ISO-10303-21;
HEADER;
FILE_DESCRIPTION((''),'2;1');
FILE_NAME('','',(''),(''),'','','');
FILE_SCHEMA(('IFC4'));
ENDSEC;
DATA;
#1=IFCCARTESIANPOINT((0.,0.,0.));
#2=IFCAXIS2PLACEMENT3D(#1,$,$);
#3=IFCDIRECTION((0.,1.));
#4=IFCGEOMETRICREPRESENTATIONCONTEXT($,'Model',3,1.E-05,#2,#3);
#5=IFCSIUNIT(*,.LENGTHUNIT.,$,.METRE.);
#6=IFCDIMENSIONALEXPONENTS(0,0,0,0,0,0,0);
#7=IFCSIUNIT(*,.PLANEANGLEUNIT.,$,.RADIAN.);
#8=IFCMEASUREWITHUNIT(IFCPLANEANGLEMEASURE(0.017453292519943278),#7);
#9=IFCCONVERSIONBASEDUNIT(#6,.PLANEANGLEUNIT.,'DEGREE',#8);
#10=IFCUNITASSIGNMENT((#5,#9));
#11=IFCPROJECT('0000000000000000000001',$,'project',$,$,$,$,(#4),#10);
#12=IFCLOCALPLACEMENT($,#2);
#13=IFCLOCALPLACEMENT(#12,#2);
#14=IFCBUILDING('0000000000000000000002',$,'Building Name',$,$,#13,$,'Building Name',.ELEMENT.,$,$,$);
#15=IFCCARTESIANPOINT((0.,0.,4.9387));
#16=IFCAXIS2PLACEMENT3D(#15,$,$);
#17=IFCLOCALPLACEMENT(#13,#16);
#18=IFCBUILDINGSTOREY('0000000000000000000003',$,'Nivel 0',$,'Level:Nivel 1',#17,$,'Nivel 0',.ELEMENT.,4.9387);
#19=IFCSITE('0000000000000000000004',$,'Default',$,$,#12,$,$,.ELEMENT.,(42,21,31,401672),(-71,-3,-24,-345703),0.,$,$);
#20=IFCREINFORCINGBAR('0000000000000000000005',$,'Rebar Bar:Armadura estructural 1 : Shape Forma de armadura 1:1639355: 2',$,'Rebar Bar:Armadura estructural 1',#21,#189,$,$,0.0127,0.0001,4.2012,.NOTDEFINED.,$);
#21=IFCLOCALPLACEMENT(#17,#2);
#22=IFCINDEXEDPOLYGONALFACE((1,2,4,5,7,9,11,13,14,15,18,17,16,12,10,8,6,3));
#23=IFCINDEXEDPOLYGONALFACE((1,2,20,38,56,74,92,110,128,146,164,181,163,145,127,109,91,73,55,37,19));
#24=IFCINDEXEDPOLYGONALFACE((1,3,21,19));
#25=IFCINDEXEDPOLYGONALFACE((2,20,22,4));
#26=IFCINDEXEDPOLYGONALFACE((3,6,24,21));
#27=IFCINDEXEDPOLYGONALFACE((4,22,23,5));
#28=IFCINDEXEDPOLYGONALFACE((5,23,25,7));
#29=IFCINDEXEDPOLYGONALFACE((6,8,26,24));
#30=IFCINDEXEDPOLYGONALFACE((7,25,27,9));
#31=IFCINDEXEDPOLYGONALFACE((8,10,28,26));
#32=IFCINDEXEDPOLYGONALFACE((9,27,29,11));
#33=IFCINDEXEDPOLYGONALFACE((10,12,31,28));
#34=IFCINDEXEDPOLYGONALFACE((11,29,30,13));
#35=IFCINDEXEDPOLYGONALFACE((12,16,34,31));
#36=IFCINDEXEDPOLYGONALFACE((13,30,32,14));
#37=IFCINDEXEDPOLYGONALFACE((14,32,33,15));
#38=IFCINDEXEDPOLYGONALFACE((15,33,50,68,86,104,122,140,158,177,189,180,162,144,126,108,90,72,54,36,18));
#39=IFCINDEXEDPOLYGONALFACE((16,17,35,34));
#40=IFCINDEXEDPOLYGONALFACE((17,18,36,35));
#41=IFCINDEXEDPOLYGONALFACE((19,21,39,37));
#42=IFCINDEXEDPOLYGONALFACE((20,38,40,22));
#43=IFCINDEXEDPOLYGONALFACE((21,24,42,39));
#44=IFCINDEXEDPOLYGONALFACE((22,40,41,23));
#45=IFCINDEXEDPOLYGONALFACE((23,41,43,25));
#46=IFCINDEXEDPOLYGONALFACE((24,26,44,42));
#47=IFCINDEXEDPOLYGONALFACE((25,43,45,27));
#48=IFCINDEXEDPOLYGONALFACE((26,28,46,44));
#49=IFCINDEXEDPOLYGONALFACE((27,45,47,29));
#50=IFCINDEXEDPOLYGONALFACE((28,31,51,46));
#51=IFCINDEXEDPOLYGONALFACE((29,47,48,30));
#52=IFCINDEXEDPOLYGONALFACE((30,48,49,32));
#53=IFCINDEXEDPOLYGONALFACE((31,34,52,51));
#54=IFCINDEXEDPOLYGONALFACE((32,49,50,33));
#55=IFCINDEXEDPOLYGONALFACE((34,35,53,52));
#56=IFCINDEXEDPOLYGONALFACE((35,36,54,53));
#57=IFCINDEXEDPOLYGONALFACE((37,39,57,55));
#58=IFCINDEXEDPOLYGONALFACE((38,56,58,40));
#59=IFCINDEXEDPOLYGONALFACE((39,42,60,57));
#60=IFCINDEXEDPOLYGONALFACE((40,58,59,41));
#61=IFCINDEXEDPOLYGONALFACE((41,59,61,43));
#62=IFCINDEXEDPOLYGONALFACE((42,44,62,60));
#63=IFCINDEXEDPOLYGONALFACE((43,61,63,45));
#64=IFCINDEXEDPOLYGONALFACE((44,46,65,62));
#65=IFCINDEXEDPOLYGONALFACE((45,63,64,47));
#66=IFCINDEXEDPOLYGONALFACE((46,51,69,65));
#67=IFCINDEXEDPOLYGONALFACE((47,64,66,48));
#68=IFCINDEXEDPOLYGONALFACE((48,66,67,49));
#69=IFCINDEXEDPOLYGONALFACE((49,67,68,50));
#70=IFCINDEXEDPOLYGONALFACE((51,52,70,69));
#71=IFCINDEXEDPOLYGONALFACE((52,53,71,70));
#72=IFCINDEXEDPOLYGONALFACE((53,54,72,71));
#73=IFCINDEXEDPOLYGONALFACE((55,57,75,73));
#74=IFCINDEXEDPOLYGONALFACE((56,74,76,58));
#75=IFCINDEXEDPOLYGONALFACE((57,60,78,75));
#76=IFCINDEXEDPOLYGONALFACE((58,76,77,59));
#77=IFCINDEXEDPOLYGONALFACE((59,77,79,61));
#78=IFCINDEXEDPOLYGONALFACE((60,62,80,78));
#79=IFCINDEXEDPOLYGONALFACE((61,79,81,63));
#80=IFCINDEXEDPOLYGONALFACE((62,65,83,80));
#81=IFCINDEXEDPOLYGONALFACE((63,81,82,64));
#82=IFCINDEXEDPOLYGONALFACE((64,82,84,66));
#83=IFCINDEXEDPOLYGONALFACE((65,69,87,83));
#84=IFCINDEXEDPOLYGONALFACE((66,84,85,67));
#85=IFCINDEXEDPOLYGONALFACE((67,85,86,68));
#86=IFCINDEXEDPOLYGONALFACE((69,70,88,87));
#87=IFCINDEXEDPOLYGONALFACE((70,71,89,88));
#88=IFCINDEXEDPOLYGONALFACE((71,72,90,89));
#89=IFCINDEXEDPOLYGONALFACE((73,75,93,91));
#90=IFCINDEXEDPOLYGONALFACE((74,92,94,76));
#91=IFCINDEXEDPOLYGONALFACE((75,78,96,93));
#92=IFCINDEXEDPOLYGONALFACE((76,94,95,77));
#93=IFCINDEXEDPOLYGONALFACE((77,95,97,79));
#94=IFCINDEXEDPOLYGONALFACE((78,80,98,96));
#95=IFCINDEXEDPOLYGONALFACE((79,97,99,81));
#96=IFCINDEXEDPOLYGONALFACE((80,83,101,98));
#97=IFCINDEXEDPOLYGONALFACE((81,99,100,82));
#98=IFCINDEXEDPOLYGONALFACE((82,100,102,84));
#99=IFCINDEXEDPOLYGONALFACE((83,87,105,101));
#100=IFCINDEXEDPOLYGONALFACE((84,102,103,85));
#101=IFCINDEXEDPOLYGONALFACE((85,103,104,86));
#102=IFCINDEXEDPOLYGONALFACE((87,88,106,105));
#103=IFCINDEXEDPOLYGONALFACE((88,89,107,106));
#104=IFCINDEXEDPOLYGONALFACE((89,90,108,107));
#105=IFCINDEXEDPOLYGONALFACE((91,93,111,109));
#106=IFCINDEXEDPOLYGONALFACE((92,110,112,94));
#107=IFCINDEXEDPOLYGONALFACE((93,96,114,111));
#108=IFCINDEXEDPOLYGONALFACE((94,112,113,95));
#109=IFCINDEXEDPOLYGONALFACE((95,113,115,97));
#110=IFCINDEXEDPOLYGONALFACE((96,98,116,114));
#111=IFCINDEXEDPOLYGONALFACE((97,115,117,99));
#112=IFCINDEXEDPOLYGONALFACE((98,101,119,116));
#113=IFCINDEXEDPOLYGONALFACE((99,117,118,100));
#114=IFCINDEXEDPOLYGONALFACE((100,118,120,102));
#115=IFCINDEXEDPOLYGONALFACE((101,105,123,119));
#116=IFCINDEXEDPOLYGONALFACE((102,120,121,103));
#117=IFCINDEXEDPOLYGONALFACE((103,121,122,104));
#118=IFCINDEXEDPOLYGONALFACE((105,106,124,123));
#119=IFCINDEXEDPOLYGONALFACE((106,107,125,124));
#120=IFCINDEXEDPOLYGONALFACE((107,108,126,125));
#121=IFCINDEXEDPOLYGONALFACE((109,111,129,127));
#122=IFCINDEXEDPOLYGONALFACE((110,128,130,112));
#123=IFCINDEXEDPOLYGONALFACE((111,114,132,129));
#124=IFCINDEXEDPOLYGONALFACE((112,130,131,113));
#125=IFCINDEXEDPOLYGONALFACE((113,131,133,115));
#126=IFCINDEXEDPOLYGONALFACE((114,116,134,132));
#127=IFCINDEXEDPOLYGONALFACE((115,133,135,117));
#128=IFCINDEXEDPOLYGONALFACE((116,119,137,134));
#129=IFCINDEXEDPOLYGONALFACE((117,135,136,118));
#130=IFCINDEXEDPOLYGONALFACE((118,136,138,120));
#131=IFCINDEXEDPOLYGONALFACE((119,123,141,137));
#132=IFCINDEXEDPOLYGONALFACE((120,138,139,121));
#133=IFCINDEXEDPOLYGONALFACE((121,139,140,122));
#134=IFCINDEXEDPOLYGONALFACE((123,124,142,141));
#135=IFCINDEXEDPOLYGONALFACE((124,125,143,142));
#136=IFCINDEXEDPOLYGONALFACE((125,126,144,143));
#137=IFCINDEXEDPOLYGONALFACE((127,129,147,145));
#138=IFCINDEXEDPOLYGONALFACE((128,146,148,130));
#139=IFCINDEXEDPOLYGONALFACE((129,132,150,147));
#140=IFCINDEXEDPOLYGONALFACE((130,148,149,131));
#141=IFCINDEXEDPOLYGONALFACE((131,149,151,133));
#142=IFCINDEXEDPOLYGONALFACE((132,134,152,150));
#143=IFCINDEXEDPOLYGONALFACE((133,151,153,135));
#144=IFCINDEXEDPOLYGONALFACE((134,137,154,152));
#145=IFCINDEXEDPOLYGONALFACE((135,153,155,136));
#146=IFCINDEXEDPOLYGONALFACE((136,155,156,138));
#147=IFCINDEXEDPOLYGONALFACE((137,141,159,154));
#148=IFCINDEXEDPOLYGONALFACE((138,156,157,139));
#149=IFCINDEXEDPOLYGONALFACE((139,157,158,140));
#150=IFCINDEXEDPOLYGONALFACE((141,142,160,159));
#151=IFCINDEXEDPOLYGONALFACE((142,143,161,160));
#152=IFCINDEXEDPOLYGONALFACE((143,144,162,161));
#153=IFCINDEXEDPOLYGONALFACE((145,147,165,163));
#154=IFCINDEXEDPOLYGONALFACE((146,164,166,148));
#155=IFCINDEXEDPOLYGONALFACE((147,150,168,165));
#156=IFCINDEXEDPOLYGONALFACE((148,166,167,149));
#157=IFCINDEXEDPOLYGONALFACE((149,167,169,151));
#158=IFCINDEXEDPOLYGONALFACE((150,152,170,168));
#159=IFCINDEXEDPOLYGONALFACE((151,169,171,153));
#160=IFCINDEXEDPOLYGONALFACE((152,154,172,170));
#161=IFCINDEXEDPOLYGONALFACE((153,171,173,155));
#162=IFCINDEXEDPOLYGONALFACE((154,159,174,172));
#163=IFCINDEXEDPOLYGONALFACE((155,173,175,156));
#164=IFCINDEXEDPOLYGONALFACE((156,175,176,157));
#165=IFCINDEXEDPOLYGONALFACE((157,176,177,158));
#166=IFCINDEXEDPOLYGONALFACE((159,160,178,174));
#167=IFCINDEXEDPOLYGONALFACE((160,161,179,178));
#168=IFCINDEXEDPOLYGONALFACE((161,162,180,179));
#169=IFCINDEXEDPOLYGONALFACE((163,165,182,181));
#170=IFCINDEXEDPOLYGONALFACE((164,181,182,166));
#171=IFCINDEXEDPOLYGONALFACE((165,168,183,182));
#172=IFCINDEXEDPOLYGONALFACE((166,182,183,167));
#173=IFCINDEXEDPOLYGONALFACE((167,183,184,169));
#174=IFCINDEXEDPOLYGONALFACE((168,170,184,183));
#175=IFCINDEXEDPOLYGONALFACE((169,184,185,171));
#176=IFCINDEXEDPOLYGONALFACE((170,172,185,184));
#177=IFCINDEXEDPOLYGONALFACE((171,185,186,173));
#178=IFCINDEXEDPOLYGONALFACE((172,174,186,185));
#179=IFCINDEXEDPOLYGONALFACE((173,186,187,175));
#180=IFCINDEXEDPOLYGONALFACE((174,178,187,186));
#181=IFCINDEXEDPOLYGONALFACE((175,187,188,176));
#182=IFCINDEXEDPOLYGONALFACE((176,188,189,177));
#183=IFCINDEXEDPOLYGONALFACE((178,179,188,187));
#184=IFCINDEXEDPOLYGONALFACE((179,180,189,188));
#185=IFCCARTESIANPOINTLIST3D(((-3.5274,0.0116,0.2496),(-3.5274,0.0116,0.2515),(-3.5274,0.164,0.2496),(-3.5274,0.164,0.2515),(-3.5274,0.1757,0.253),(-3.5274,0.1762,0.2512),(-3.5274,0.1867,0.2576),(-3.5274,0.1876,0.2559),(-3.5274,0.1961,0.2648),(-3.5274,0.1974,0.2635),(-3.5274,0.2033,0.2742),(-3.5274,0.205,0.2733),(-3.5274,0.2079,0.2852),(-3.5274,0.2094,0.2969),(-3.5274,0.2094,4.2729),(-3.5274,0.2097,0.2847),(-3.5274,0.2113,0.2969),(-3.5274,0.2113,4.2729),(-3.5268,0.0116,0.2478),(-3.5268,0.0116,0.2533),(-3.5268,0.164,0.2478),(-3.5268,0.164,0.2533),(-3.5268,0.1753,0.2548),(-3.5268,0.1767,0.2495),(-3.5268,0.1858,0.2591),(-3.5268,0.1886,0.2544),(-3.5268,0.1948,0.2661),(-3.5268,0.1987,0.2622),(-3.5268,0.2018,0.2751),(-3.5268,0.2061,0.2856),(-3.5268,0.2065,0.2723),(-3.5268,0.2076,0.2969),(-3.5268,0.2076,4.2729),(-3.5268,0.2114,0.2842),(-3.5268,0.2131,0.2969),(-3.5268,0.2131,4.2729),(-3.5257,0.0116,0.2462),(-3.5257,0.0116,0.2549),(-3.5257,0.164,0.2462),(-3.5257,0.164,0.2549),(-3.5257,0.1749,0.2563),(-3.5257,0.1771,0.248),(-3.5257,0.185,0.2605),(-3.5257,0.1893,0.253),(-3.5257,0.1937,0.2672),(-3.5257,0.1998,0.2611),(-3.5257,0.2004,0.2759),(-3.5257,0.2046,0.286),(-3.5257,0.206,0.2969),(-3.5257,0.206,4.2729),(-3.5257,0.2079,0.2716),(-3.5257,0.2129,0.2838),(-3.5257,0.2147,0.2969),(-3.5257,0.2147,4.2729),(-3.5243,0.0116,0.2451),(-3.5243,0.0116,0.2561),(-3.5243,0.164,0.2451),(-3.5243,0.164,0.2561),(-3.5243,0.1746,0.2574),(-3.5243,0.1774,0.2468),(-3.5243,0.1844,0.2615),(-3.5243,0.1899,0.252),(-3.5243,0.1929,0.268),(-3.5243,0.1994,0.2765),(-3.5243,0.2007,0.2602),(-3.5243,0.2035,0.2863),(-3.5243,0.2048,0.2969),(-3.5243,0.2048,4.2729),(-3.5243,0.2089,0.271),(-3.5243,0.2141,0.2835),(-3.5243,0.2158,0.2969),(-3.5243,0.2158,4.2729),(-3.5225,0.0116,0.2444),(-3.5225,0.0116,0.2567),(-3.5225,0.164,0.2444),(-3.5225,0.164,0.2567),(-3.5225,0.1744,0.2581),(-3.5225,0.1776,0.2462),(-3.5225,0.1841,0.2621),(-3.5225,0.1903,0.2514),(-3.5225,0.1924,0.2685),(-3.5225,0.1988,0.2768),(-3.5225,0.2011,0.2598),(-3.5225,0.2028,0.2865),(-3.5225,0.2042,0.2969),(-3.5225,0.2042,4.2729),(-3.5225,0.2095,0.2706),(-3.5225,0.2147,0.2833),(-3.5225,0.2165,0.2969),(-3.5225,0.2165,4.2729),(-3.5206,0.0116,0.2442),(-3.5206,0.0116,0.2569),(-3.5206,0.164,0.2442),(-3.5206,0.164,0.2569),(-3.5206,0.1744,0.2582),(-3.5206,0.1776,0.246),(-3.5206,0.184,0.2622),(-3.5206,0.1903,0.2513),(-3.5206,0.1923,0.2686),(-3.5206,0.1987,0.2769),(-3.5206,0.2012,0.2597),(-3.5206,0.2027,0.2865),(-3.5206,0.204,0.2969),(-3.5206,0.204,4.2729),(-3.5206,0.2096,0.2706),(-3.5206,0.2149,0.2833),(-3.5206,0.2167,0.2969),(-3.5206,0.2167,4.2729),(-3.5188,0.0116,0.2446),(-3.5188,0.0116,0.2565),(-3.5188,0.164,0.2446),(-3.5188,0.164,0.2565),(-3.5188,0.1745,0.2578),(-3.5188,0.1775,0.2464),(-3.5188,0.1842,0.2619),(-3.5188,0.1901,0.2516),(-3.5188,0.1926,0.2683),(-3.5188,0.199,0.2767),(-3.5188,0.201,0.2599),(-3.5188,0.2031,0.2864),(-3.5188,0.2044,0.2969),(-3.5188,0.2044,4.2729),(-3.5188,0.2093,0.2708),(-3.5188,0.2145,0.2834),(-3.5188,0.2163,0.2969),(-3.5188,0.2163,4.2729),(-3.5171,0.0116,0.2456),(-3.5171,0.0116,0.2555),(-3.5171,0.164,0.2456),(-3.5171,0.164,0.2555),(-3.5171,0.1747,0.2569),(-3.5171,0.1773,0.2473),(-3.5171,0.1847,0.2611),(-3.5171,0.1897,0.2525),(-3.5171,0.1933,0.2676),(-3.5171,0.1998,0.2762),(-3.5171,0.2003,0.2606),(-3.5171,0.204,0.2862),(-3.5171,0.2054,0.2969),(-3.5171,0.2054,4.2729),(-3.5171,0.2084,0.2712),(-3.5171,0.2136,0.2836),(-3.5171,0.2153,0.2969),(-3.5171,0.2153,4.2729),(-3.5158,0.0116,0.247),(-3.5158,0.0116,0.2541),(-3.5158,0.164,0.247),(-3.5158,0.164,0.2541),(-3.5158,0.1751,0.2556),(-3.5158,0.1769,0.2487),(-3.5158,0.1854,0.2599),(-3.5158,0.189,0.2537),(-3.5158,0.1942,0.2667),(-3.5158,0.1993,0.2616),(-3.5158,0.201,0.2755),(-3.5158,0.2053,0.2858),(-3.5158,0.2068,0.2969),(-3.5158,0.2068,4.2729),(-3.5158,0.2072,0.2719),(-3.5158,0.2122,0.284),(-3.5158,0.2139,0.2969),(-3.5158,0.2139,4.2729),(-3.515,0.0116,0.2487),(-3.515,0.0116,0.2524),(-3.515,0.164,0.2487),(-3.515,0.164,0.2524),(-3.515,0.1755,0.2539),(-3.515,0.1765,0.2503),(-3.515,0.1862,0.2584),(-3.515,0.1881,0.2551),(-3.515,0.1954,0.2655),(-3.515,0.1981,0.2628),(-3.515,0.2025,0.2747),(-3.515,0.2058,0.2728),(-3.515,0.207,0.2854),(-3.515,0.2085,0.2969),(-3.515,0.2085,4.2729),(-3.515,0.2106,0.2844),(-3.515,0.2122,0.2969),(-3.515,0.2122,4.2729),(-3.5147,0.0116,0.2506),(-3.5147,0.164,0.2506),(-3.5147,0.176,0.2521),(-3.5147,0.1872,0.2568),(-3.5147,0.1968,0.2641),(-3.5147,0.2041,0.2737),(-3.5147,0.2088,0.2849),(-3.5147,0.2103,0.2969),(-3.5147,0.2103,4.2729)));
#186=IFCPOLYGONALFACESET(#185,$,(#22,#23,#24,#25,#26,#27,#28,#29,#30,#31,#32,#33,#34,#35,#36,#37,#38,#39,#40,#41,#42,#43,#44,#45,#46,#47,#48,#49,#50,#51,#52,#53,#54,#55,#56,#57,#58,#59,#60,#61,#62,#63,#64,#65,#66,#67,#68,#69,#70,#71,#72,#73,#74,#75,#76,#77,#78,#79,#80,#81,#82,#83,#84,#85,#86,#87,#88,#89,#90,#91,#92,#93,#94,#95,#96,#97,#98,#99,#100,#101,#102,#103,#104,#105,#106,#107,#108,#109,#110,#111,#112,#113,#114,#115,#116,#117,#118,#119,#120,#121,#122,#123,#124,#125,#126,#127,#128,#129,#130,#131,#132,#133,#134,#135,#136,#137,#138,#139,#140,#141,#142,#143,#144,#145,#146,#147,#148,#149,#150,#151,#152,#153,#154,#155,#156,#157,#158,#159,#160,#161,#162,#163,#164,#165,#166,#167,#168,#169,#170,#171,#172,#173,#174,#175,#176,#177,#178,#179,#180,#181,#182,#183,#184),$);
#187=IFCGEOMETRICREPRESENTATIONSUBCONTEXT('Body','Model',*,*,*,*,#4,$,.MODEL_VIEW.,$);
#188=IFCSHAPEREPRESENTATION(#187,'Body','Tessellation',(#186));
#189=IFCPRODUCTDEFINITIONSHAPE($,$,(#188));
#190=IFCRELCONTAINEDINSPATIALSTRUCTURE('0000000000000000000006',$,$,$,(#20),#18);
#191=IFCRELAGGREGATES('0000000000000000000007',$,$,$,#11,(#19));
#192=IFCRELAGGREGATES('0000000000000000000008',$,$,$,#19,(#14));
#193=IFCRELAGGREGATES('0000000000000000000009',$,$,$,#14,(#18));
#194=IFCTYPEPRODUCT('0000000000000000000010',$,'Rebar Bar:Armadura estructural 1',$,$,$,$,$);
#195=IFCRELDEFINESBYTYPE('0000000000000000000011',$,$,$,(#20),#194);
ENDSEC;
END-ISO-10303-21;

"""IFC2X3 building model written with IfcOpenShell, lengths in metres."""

from ifc_helpers import new_model, entity, si_unit, converted_unit, direction, frame, origin, place, context, subcontext, project, spatial, type_object, element, save


model = new_model("IFC2X3")

# Units and contexts
model_context = context("Model", 3, precision=1e-05, world=origin(), true_north=direction((0.0, 1.0)))
body_context = subcontext(model_context, "Body", "Model", "MODEL_VIEW")
ifc_project = project(units=[si_unit("LENGTHUNIT", "METRE"), converted_unit("PLANEANGLEUNIT", "DEGREE", entity("IfcPlaneAngleMeasure", 0.017453292519943278), si_unit("PLANEANGLEUNIT", "RADIAN"), dimensions=[0, 0, 0, 0, 0, 0, 0])], contexts=[model_context])

# Site, building, storey
site_placement = place(None, origin())
site = spatial("IfcSite", under=ifc_project, at=site_placement, Name="Default", CompositionType="ELEMENT", RefLatitude=(42, 21, 31, 401672), RefLongitude=(-71, -3, -24, -345703), RefElevation=0.0)
building_placement = place(site_placement, origin())
building = spatial("IfcBuilding", under=site, at=building_placement, Name="Building Name", LongName="Building Name", CompositionType="ELEMENT")
storey_placement = place(building_placement, frame((0.0, 0.0, 4.9387)))
storey = spatial("IfcBuildingStorey", under=building, at=storey_placement, Name="Nivel 0", ObjectType="Level:Nivel 1", LongName="Nivel 0", CompositionType="ELEMENT", Elevation=4.9387)

# Reinforcing bar
type_product = type_object("IfcTypeProduct", Name="Rebar Bar:Armadura estructural 1")
reinforcing_bar_1_placement = place(storey_placement, origin())
element("IfcReinforcingBar", 1, at=reinforcing_bar_1_placement, inside=storey, type_object=type_product, Name="Rebar Bar:Armadura estructural 1 : Shape Forma de armadura 1:1639355: 2", ObjectType="Rebar Bar:Armadura estructural 1", BarLength=4.2012, BarRole="NOTDEFINED", CrossSectionArea=0.0001, NominalDiameter=0.0127, context=body_context, shape_type="AdvancedSweptSolid", body=[
    entity("IfcSweptDiskSolid", entity("IfcCompositeCurve", [entity("IfcCompositeCurveSegment", "CONTINUOUS", True, entity("IfcPolyline", [entity("IfcCartesianPoint", [-3.5211, 0.0116, 0.2506]), entity("IfcCartesianPoint", [-3.5211, 0.164, 0.2506])])), entity("IfcCompositeCurveSegment", "CONTINUOUS", True, entity("IfcTrimmedCurve", entity("IfcCircle", entity("IfcAxis2Placement3D", entity("IfcCartesianPoint", [-3.5211, 0.164, 0.2969]), entity("IfcDirection", [1.0, 0.0, 0.0]), entity("IfcDirection", [0.0, 1.0, 0.0])), 0.0464), [entity("IfcParameterValue", 270.0)], [entity("IfcParameterValue", 360.0)], True, "PARAMETER")), entity("IfcCompositeCurveSegment", "CONTINUOUS", True, entity("IfcPolyline", [entity("IfcCartesianPoint", [-3.5211, 0.2103, 0.2969]), entity("IfcCartesianPoint", [-3.5211, 0.2103, 4.2729])]))], False), 0.0063, None, 0.0, 92.0),
])

save(model, "model.ifc")
